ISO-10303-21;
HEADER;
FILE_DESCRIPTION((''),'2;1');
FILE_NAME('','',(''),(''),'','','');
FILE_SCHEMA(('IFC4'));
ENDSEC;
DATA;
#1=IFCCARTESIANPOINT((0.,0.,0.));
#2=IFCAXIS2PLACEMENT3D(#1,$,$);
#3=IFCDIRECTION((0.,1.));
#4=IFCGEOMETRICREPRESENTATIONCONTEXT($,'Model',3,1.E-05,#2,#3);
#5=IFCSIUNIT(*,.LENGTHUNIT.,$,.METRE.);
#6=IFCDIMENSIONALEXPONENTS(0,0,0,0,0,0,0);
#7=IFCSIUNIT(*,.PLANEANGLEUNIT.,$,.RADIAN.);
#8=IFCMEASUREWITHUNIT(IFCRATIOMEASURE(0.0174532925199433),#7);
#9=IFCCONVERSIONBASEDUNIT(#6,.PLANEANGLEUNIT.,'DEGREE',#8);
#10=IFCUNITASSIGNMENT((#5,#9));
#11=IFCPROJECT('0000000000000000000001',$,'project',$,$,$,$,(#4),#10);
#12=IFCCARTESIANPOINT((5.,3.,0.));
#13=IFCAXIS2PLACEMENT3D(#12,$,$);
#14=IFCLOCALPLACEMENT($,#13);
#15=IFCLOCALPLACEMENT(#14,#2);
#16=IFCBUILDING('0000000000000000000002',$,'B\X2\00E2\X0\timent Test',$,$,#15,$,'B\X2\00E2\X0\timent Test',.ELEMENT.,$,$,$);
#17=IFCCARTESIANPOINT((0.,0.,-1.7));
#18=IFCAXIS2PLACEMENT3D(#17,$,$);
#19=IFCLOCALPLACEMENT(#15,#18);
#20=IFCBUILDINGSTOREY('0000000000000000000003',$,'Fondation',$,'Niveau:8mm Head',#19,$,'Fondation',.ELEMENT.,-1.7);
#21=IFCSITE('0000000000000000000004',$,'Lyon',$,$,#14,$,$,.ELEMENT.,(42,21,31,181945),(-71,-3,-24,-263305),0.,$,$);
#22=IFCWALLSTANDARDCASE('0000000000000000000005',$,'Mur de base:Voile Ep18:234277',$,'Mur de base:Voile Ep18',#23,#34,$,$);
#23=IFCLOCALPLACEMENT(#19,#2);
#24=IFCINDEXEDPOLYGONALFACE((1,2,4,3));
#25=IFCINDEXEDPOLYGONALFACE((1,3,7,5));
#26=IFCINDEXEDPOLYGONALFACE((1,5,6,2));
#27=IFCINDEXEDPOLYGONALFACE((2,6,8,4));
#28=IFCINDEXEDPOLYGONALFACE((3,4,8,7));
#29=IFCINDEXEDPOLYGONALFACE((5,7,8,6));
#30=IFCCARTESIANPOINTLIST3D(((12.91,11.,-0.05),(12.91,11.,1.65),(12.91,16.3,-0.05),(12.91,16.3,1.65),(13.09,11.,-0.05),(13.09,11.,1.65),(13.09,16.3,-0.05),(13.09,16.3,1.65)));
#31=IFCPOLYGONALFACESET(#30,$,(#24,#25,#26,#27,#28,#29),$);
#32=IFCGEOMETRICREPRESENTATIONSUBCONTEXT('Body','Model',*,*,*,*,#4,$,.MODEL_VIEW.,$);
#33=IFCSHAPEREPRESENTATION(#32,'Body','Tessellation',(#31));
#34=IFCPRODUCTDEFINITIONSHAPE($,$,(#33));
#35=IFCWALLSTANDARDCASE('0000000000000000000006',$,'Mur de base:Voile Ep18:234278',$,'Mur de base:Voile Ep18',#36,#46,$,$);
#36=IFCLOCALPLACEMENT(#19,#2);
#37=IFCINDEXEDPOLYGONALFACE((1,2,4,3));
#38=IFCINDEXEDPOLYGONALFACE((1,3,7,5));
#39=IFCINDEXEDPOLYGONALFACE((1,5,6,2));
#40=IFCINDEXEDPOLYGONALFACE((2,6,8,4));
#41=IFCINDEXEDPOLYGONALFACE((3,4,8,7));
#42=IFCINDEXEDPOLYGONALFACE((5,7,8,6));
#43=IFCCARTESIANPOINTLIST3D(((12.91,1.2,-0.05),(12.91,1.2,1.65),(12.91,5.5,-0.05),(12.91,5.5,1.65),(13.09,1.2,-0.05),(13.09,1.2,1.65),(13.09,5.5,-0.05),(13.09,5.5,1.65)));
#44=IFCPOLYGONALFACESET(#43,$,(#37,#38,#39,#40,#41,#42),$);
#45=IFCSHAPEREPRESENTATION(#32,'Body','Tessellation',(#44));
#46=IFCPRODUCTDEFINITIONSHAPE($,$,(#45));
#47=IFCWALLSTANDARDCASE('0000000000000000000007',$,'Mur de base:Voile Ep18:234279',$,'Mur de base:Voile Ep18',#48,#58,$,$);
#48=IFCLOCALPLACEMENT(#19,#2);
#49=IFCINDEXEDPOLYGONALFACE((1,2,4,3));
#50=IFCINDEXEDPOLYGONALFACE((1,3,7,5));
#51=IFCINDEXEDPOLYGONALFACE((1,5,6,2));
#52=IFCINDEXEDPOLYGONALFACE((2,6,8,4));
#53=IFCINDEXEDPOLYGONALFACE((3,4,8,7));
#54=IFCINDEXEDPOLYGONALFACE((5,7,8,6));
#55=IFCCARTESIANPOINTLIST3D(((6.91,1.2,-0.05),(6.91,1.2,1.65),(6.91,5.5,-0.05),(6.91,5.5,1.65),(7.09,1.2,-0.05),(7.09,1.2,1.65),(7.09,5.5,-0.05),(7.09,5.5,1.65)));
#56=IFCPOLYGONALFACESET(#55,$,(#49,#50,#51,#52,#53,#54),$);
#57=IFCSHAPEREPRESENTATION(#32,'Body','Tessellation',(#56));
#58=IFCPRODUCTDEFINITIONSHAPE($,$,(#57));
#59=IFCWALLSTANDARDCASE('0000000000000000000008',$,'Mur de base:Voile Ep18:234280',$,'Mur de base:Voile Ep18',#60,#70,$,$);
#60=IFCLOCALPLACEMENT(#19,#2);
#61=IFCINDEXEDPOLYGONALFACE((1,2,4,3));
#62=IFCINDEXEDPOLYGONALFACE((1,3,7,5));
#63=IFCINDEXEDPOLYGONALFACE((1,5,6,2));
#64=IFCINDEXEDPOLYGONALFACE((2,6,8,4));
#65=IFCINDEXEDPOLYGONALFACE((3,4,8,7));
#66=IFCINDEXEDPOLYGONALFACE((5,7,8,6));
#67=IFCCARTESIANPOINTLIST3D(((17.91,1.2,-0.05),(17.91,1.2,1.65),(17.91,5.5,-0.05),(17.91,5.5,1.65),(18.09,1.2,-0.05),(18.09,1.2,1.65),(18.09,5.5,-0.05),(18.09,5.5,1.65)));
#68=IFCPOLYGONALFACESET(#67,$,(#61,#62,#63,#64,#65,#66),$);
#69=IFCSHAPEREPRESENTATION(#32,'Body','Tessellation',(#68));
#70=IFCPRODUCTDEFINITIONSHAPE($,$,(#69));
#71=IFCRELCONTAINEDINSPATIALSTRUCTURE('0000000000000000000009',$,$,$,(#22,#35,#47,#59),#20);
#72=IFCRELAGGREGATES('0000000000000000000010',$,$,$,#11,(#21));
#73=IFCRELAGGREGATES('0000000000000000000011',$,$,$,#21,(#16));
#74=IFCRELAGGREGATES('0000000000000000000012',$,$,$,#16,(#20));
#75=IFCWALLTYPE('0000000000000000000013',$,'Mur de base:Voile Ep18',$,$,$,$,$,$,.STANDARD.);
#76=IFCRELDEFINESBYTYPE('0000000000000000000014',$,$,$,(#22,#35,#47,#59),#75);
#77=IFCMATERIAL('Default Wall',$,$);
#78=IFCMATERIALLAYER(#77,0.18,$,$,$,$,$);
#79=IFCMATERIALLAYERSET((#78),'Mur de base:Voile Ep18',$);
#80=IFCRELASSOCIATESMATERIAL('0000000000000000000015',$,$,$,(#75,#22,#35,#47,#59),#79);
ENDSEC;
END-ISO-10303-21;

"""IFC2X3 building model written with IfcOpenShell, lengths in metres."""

from ifc_helpers import new_model, entity, si_unit, converted_unit, direction, frame, frame_2d, origin, place, context, subcontext, project, spatial, rectangle, extrude, material, layer, layer_set, layer_usage, type_object, element, save


model = new_model("IFC2X3")

# Units and contexts
model_context = context("Model", 3, precision=1e-05, world=origin(), true_north=direction((0.0, 1.0)))
body_context = subcontext(model_context, "Body", "Model", "MODEL_VIEW")
ifc_project = project(units=[si_unit("LENGTHUNIT", "METRE"), converted_unit("PLANEANGLEUNIT", "DEGREE", entity("IfcRatioMeasure", 0.0174532925199433), si_unit("PLANEANGLEUNIT", "RADIAN"), dimensions=[0, 0, 0, 0, 0, 0, 0])], contexts=[model_context])

# Site, building, storey
site_placement = place(None, frame((5.0, 3.0, 0.0)))
site = spatial("IfcSite", under=ifc_project, at=site_placement, Name="Lyon", CompositionType="ELEMENT", RefLatitude=(42, 21, 31, 181945), RefLongitude=(-71, -3, -24, -263305), RefElevation=0.0)
building_placement = place(site_placement, origin())
building = spatial("IfcBuilding", under=site, at=building_placement, Name="Bâtiment Test", LongName="Bâtiment Test", CompositionType="ELEMENT")
storey_placement = place(building_placement, frame((0.0, 0.0, -1.7)))
storey = spatial("IfcBuildingStorey", under=building, at=storey_placement, Name="Fondation", ObjectType="Niveau:8mm Head", LongName="Fondation", CompositionType="ELEMENT", Elevation=-1.7)

# Walls
ifc_material_1 = material(Name="Default Wall")
ifc_layer_1 = layer(ifc_material_1, 0.18)
ifc_layer_set_1 = layer_set([ifc_layer_1], Name="Mur de base:Voile Ep18")
wall_type_1 = type_object("IfcWallType", Name="Mur de base:Voile Ep18", PredefinedType="STANDARD", material=ifc_layer_set_1)
ifc_layer_usage_1 = layer_usage(ifc_layer_set_1, "AXIS2", "NEGATIVE", 0.09)
wall_1_placement = place(storey_placement, frame((13.0, 16.3, -0.05), z_axis=(0.0, 0.0, 1.0), x_axis=(0.0, -1.0, 0.0)))
element("IfcWallStandardCase", 1, at=wall_1_placement, inside=storey, type_object=wall_type_1, material=ifc_layer_usage_1, Name="Mur de base:Voile Ep18:234277", ObjectType="Mur de base:Voile Ep18", context=body_context, shape_type="SweptSolid", body=[
    extrude(rectangle(XDim=5.3, YDim=0.18, at=frame_2d((2.65, 0.0), x_axis=(-1.0, 0.0))), origin(), (0.0, 0.0, 1.0), 1.7),
])
ifc_layer_usage_2 = layer_usage(ifc_layer_set_1, "AXIS2", "NEGATIVE", 0.09)
wall_2_placement = place(storey_placement, frame((13.0, 1.2, -0.05), z_axis=(0.0, 0.0, 1.0), x_axis=(0.0, 1.0, 0.0)))
element("IfcWallStandardCase", 2, at=wall_2_placement, inside=storey, type_object=wall_type_1, material=ifc_layer_usage_2, Name="Mur de base:Voile Ep18:234278", ObjectType="Mur de base:Voile Ep18", context=body_context, shape_type="SweptSolid", body=[
    extrude(rectangle(XDim=4.3, YDim=0.18, at=frame_2d((2.15, 0.0), x_axis=(-1.0, 0.0))), origin(), (0.0, 0.0, 1.0), 1.7),
])
ifc_layer_usage_3 = layer_usage(ifc_layer_set_1, "AXIS2", "NEGATIVE", 0.09)
wall_3_placement = place(storey_placement, frame((7.0, 1.2, -0.05), z_axis=(0.0, 0.0, 1.0), x_axis=(0.0, 1.0, 0.0)))
element("IfcWallStandardCase", 3, at=wall_3_placement, inside=storey, type_object=wall_type_1, material=ifc_layer_usage_3, Name="Mur de base:Voile Ep18:234279", ObjectType="Mur de base:Voile Ep18", context=body_context, shape_type="SweptSolid", body=[
    extrude(rectangle(XDim=4.3, YDim=0.18, at=frame_2d((2.15, 0.0), x_axis=(-1.0, 0.0))), origin(), (0.0, 0.0, 1.0), 1.7),
])
ifc_layer_usage_4 = layer_usage(ifc_layer_set_1, "AXIS2", "NEGATIVE", 0.09)
wall_4_placement = place(storey_placement, frame((18.0, 1.2, -0.05), z_axis=(0.0, 0.0, 1.0), x_axis=(0.0, 1.0, 0.0)))
element("IfcWallStandardCase", 4, at=wall_4_placement, inside=storey, type_object=wall_type_1, material=ifc_layer_usage_4, Name="Mur de base:Voile Ep18:234280", ObjectType="Mur de base:Voile Ep18", context=body_context, shape_type="SweptSolid", body=[
    extrude(rectangle(XDim=4.3, YDim=0.18, at=frame_2d((2.15, 0.0), x_axis=(-1.0, 0.0))), origin(), (0.0, 0.0, 1.0), 1.7),
])

save(model, "model.ifc")
